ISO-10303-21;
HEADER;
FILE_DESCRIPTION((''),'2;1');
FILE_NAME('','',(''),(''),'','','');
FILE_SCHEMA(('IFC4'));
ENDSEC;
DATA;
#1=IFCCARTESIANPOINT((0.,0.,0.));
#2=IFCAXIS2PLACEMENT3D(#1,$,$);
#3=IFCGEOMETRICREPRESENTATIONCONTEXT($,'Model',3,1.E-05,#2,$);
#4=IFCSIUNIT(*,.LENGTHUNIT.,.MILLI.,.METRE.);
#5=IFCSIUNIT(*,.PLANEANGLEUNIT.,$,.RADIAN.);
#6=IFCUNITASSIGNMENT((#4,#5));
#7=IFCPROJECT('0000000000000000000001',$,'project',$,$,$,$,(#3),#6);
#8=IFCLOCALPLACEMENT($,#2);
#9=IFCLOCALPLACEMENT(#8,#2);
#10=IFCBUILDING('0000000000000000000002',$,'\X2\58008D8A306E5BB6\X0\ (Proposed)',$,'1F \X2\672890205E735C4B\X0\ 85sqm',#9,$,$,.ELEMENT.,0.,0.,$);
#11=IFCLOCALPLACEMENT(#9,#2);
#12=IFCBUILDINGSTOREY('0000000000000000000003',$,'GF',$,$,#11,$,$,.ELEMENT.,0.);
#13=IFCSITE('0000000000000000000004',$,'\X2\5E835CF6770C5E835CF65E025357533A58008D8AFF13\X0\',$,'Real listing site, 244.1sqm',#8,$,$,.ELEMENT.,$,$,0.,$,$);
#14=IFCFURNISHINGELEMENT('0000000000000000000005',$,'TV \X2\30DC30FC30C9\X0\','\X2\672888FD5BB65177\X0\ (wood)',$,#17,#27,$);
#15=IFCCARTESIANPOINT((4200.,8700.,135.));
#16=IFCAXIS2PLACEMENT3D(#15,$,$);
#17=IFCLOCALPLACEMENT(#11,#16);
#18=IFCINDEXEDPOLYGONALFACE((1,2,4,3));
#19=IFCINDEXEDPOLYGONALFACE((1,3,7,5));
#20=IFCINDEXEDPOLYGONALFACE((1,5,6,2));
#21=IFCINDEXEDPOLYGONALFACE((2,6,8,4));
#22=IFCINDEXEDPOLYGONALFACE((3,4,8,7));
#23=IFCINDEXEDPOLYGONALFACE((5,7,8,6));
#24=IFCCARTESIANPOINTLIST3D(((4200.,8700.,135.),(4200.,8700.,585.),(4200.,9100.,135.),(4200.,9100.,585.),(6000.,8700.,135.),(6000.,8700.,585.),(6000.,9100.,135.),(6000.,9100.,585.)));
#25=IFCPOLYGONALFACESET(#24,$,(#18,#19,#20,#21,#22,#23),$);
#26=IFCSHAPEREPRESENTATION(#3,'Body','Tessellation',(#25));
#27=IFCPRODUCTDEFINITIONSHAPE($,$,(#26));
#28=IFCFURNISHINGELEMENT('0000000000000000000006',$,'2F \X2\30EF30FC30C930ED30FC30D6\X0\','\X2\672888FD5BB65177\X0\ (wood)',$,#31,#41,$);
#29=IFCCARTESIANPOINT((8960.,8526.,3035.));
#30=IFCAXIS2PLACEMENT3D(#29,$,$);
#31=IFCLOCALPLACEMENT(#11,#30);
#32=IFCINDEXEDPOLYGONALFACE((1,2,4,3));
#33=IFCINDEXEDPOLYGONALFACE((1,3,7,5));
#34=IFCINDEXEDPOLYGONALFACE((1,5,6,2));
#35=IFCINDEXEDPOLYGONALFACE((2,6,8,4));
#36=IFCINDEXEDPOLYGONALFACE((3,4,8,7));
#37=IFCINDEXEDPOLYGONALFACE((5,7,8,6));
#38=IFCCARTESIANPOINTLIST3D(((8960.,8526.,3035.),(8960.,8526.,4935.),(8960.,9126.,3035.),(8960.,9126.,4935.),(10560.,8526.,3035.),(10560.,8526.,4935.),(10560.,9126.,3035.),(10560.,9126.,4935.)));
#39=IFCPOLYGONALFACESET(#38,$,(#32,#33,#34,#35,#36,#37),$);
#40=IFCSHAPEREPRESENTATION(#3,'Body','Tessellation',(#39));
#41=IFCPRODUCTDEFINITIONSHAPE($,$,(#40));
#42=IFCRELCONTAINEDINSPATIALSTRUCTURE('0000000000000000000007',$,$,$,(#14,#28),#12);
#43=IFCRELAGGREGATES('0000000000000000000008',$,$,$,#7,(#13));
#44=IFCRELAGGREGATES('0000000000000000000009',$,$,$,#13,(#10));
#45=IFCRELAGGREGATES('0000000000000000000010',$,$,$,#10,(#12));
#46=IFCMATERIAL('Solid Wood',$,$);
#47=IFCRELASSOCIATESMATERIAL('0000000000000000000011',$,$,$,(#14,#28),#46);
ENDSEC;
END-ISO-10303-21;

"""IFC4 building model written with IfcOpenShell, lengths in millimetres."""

from ifc_helpers import new_model, si_unit, frame, frame_2d, origin, place, context, project, spatial, rectangle, extrude, material, element, save


model = new_model("IFC4")

# Units and contexts
model_context = context("Model", 3, precision=1e-05, world=origin())
ifc_project = project(units=[si_unit("LENGTHUNIT", "METRE", prefix="MILLI"), si_unit("PLANEANGLEUNIT", "RADIAN")], contexts=[model_context])

# Site, building, storey
site_placement = place(None, origin())
site = spatial("IfcSite", under=ifc_project, at=site_placement, Name="広島県広島市南区堀越３", ObjectType="Real listing site, 244.1sqm", CompositionType="ELEMENT", RefElevation=0.0)
building_placement = place(site_placement, origin())
building = spatial("IfcBuilding", under=site, at=building_placement, Name="堀越の家 (Proposed)", ObjectType="1F 木造平屋 85sqm", CompositionType="ELEMENT", ElevationOfRefHeight=0.0, ElevationOfTerrain=0.0)
storey_placement = place(building_placement, origin())
storey = spatial("IfcBuildingStorey", under=building, at=storey_placement, Name="GF", CompositionType="ELEMENT", Elevation=0.0)

# Shared definitions
ifc_material_1 = material(Name="Solid Wood")

# Furnishing elements
furnishing_1_placement = place(storey_placement, frame((4200.0, 8700.0, 135.0)))
element("IfcFurnishingElement", 1, at=furnishing_1_placement, inside=storey, material=ifc_material_1, Name="TV ボード", Description="木製家具 (wood)", context=model_context, shape_type="SweptSolid", body=[
    extrude(rectangle(XDim=1800.0, YDim=400.0, at=frame_2d((900.0, 200.0))), frame((4200.0, 8700.0, 135.0)), (0.0, 0.0, 1.0), 450.0),
])
furnishing_2_placement = place(storey_placement, frame((8960.0, 8526.0, 3035.0)))
element("IfcFurnishingElement", 2, at=furnishing_2_placement, inside=storey, material=ifc_material_1, Name="2F ワードローブ", Description="木製家具 (wood)", context=model_context, shape_type="SweptSolid", body=[
    extrude(rectangle(XDim=1600.0, YDim=600.0, at=frame_2d((800.0, 300.0))), frame((8960.0, 8526.0, 3035.0)), (0.0, 0.0, 1.0), 1900.0),
])

save(model, "model.ifc")
